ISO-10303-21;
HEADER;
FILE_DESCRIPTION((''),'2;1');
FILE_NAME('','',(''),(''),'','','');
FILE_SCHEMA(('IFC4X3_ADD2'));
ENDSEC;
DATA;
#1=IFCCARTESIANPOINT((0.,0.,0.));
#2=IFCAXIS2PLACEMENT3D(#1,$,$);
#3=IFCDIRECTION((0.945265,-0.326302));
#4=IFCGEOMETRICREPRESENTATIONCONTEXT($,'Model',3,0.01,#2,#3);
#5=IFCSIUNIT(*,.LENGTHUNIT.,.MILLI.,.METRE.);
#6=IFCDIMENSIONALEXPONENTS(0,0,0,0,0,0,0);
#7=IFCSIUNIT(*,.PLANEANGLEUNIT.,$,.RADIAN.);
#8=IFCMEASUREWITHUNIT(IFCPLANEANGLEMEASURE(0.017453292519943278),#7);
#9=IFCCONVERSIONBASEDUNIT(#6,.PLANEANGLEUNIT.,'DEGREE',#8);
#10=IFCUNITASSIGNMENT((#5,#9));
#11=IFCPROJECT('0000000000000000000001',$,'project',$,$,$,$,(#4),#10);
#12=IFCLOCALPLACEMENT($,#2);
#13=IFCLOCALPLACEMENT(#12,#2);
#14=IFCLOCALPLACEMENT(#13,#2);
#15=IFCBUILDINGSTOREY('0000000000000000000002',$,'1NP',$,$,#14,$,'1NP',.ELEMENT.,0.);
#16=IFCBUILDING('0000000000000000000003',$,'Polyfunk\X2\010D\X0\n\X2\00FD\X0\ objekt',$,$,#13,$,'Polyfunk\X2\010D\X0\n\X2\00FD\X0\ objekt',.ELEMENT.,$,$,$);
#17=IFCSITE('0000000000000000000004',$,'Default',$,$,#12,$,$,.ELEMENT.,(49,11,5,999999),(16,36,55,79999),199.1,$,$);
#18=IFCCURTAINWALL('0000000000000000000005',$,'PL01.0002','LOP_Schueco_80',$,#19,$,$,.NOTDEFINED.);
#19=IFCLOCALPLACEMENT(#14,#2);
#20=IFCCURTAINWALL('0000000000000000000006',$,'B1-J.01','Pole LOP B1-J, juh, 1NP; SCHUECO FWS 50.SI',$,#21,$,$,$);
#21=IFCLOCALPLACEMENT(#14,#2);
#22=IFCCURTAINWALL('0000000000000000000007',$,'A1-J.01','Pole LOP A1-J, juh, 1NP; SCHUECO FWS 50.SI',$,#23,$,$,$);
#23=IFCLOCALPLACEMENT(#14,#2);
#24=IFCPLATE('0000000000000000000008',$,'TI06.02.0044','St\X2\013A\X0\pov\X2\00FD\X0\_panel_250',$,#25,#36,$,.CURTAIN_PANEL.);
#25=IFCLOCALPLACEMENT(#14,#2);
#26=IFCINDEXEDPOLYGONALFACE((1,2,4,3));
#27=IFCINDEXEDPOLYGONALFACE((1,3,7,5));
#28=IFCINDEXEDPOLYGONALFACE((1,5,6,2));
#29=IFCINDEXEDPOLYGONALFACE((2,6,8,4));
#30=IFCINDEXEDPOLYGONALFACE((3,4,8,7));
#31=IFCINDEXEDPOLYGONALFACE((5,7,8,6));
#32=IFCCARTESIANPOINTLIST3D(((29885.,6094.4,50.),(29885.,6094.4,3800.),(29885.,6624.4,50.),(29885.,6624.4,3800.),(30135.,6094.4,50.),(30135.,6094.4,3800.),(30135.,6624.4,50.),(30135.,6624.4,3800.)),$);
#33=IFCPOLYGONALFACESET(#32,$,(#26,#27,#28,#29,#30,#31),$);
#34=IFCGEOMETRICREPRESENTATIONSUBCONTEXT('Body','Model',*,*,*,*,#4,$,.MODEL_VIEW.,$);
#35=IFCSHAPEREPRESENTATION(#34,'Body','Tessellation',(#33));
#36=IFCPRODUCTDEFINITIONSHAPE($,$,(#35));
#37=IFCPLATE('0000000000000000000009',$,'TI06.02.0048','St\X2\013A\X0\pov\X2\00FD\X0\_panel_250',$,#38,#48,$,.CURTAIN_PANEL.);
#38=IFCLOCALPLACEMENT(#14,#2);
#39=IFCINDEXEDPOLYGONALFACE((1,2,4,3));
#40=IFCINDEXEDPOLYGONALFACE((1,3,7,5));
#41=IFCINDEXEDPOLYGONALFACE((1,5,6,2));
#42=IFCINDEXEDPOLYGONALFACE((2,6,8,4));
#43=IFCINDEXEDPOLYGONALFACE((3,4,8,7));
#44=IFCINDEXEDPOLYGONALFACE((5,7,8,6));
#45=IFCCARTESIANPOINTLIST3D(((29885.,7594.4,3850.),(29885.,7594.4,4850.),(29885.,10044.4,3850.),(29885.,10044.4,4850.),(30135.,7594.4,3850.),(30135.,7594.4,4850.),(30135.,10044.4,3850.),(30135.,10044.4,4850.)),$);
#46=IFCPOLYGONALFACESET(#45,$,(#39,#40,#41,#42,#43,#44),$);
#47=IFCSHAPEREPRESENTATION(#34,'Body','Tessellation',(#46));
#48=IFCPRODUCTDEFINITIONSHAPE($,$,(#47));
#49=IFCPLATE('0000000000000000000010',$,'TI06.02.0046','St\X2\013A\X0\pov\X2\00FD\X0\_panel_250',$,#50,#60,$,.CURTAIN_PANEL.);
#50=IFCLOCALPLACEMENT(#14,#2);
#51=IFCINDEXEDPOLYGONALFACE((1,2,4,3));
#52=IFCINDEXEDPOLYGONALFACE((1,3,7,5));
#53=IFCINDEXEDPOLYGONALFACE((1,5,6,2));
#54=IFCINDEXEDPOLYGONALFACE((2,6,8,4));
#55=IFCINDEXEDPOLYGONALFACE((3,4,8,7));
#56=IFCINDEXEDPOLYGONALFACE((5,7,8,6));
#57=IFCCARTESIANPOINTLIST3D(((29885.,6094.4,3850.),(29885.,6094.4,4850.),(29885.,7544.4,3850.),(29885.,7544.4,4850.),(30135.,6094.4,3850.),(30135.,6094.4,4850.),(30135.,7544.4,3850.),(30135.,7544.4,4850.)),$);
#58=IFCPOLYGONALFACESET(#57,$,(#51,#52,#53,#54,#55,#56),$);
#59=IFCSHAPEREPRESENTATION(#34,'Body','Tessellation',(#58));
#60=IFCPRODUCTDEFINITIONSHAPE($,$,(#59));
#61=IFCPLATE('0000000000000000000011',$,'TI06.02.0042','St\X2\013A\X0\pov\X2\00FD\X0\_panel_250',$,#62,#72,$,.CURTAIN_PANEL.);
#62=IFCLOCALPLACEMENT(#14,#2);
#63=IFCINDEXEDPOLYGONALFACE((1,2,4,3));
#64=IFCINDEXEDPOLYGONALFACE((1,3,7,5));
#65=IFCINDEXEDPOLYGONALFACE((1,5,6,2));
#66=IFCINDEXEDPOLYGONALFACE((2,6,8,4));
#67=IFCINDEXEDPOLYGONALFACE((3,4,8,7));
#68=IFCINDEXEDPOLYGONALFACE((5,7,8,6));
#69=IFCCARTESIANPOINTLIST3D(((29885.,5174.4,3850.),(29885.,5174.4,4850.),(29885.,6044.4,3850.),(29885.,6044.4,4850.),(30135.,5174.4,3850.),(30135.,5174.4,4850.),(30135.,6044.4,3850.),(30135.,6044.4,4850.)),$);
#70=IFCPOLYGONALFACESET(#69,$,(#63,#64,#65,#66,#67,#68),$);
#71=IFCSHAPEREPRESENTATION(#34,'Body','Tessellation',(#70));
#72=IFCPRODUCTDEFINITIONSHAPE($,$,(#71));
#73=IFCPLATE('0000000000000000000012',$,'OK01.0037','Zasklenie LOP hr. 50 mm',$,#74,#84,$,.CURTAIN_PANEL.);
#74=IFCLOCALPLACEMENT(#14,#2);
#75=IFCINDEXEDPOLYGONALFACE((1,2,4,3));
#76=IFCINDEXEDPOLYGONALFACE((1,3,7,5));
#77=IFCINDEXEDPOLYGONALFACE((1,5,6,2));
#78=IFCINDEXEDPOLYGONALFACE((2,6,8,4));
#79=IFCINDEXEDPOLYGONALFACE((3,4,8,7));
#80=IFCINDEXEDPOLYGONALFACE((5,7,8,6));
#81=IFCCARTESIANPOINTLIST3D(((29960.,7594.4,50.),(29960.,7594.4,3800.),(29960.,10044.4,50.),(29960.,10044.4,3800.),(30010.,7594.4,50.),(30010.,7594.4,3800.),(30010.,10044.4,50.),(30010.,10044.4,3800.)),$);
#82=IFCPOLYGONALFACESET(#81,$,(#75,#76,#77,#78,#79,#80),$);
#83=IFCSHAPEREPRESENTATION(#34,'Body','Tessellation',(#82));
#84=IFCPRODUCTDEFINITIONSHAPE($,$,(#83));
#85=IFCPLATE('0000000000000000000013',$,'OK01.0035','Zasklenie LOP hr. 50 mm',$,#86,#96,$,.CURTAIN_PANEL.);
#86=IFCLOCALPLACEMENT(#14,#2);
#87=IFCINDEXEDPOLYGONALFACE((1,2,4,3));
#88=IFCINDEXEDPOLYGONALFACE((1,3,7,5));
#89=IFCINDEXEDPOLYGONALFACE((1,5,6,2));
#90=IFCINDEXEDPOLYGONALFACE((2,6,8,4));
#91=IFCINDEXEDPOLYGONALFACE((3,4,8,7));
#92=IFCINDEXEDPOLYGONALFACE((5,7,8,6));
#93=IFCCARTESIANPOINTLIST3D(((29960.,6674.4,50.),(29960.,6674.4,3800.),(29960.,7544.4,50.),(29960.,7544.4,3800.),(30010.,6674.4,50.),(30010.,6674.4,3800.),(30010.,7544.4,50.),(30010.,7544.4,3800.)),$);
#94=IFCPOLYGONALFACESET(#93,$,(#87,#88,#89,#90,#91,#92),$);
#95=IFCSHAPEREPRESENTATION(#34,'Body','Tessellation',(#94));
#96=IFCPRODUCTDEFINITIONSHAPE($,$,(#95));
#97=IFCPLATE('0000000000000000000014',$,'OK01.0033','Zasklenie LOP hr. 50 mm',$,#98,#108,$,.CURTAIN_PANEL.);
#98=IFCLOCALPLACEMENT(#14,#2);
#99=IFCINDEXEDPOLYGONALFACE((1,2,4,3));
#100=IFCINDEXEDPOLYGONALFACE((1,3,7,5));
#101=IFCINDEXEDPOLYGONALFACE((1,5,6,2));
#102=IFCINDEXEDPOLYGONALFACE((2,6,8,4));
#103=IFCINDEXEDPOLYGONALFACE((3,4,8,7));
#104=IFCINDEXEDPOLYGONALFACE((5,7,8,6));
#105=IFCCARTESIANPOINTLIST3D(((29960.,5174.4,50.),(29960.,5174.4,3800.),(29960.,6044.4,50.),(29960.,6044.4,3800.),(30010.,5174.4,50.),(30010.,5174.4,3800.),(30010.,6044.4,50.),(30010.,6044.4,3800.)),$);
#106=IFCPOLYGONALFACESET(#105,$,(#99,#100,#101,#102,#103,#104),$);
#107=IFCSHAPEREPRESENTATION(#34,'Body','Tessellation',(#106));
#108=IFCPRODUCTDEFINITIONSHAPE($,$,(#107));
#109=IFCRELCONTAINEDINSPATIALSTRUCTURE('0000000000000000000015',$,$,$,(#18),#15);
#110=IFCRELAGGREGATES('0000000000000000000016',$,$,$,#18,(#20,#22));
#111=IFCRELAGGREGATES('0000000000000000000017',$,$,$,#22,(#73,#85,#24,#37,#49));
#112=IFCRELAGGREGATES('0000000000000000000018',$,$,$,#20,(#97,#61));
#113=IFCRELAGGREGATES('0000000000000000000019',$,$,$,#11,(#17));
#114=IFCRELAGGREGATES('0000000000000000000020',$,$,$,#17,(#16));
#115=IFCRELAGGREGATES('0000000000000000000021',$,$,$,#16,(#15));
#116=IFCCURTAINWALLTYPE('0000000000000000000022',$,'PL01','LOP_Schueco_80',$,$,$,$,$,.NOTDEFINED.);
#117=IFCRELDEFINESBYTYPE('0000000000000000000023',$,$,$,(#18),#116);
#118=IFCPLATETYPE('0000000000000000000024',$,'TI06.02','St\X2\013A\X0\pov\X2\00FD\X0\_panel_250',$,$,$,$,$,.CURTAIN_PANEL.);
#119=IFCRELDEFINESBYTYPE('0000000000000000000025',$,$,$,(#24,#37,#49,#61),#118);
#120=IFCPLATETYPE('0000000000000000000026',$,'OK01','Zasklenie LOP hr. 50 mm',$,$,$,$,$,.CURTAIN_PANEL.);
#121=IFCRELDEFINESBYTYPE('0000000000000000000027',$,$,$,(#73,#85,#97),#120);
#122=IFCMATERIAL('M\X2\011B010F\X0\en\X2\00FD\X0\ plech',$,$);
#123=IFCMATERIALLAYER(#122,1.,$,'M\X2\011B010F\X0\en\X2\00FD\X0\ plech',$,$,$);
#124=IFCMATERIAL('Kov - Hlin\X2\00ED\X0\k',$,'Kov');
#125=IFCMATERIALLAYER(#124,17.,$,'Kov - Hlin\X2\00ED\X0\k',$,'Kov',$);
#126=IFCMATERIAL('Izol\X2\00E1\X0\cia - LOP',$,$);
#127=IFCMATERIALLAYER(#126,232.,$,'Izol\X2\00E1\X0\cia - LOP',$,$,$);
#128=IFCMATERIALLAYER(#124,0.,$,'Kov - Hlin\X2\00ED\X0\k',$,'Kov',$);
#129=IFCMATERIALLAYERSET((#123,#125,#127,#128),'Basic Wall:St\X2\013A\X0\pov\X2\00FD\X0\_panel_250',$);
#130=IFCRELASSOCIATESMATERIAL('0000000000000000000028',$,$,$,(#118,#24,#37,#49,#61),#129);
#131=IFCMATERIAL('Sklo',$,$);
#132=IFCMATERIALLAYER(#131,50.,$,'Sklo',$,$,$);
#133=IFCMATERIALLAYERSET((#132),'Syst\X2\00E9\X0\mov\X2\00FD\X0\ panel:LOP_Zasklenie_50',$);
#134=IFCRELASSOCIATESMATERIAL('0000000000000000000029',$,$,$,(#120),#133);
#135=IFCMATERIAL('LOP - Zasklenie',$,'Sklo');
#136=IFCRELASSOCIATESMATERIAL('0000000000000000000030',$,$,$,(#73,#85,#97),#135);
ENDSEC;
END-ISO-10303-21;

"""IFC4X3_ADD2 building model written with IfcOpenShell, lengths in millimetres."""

from ifc_helpers import new_model, entity, si_unit, converted_unit, direction, frame, frame_2d, origin, place, context, subcontext, project, spatial, rectangle, extrude, source, transform, mapped, material, layer, layer_set, layer_usage, type_object, type_shapes, element, aggregate, save


model = new_model("IFC4X3_ADD2")

# Units and contexts
model_context = context("Model", 3, precision=0.01, world=origin(), true_north=direction((0.945265, -0.326302)))
body_context = subcontext(model_context, "Body", "Model", "MODEL_VIEW")
ifc_project = project(units=[si_unit("LENGTHUNIT", "METRE", prefix="MILLI"), converted_unit("PLANEANGLEUNIT", "DEGREE", entity("IfcPlaneAngleMeasure", 0.017453292519943278), si_unit("PLANEANGLEUNIT", "RADIAN"), dimensions=[0, 0, 0, 0, 0, 0, 0])], contexts=[model_context])

# Site, building, storey
site_placement = place(None, origin())
site = spatial("IfcSite", under=ifc_project, at=site_placement, Name="Default", CompositionType="ELEMENT", RefLatitude=(49, 11, 5, 999999), RefLongitude=(16, 36, 55, 79999), RefElevation=199.1)
building_placement = place(site_placement, origin())
building = spatial("IfcBuilding", under=site, at=building_placement, Name="Polyfunkčný objekt", LongName="Polyfunkčný objekt", CompositionType="ELEMENT")
storey_placement = place(building_placement, origin())
storey = spatial("IfcBuildingStorey", under=building, at=storey_placement, Name="1NP", LongName="1NP", CompositionType="ELEMENT", Elevation=0.0)

# Curtain walls, plates
curtain_wall_type = type_object("IfcCurtainWallType", Name="PL01", Description="LOP_Schueco_80", PredefinedType="NOTDEFINED")
curtain_wall_1_placement = place(storey_placement, origin())
curtain_wall_1 = element("IfcCurtainWall", 1, at=curtain_wall_1_placement, inside=storey, type_object=curtain_wall_type, Name="PL01.0002", Description="LOP_Schueco_80", PredefinedType="NOTDEFINED")
curtain_wall_2 = element("IfcCurtainWall", 2, Name="B1-J.01", Description="Pole LOP B1-J, juh, 1NP; SCHUECO FWS 50.SI")
curtain_wall_3 = element("IfcCurtainWall", 3, Name="A1-J.01", Description="Pole LOP A1-J, juh, 1NP; SCHUECO FWS 50.SI")
aggregate(curtain_wall_1, [curtain_wall_2, curtain_wall_3])
ifc_material_1 = material(Name="Měďený plech")
ifc_layer_1 = layer(ifc_material_1, 1.0, Name="Měďený plech")
ifc_material_2 = material(Name="Kov - Hliník", Category="Kov")
ifc_layer_2 = layer(ifc_material_2, 17.0, Name="Kov - Hliník", Category="Kov")
ifc_material_3 = material(Name="Izolácia - LOP")
ifc_layer_3 = layer(ifc_material_3, 232.0, Name="Izolácia - LOP")
ifc_layer_4 = layer(ifc_material_2, 0.0, Name="Kov - Hliník", Category="Kov")
ifc_layer_set_1 = layer_set([ifc_layer_1, ifc_layer_2, ifc_layer_3, ifc_layer_4], Name="Basic Wall:Stĺpový_panel_250")
ifc_layer_usage_1 = layer_usage(ifc_layer_set_1, "AXIS2", "POSITIVE", -125.0)
plate_type_1 = type_object("IfcPlateType", Name="TI06.02", Description="Stĺpový_panel_250", PredefinedType="CURTAIN_PANEL", material=ifc_layer_set_1)
plate_1_placement = place(storey_placement, frame((30010.0, 6624.4, 50.0), z_axis=(0.0, 0.0, 1.0), x_axis=(0.0, -1.0, 0.0)))
plate_1 = element("IfcPlate", 4, at=plate_1_placement, type_object=plate_type_1, material=ifc_layer_usage_1, Name="TI06.02.0044", Description="Stĺpový_panel_250", PredefinedType="CURTAIN_PANEL", context=body_context, shape_type="SweptSolid", body=[
    extrude(rectangle(XDim=250.0, YDim=530.0, at=frame_2d((0.0, 0.0), x_axis=(1.0, 0.0))), frame((265.0, 0.0, 0.0), z_axis=(0.0, 0.0, 1.0), x_axis=(0.0, 1.0, 0.0)), (0.0, 0.0, 1.0), 3750.0),
])
ifc_layer_usage_2 = layer_usage(ifc_layer_set_1, "AXIS2", "POSITIVE", -125.0)
plate_2_placement = place(storey_placement, frame((30010.0, 10044.4, 3850.0), z_axis=(0.0, 0.0, 1.0), x_axis=(0.0, -1.0, 0.0)))
plate_2 = element("IfcPlate", 5, at=plate_2_placement, type_object=plate_type_1, material=ifc_layer_usage_2, Name="TI06.02.0048", Description="Stĺpový_panel_250", PredefinedType="CURTAIN_PANEL", context=body_context, shape_type="SweptSolid", body=[
    extrude(rectangle(XDim=250.0, YDim=2450.0, at=frame_2d((0.0, 0.0), x_axis=(1.0, 0.0))), frame((1225.0, 0.0, 0.0), z_axis=(0.0, 0.0, 1.0), x_axis=(0.0, 1.0, 0.0)), (0.0, 0.0, 1.0), 1000.0),
])
ifc_layer_usage_3 = layer_usage(ifc_layer_set_1, "AXIS2", "POSITIVE", -125.0)
plate_3_placement = place(storey_placement, frame((30010.0, 7544.4, 3850.0), z_axis=(0.0, 0.0, 1.0), x_axis=(0.0, -1.0, 0.0)))
plate_3 = element("IfcPlate", 6, at=plate_3_placement, type_object=plate_type_1, material=ifc_layer_usage_3, Name="TI06.02.0046", Description="Stĺpový_panel_250", PredefinedType="CURTAIN_PANEL", context=body_context, shape_type="SweptSolid", body=[
    extrude(rectangle(XDim=250.0, YDim=1450.0, at=frame_2d((0.0, 0.0), x_axis=(1.0, 0.0))), frame((725.0, 0.0, 0.0), z_axis=(0.0, 0.0, 1.0), x_axis=(0.0, 1.0, 0.0)), (0.0, 0.0, 1.0), 1000.0),
])
ifc_layer_usage_4 = layer_usage(ifc_layer_set_1, "AXIS2", "POSITIVE", -125.0)
plate_4_placement = place(storey_placement, frame((30010.0, 6044.4, 3850.0), z_axis=(0.0, 0.0, 1.0), x_axis=(0.0, -1.0, 0.0)))
plate_4 = element("IfcPlate", 7, at=plate_4_placement, type_object=plate_type_1, material=ifc_layer_usage_4, Name="TI06.02.0042", Description="Stĺpový_panel_250", PredefinedType="CURTAIN_PANEL", context=body_context, shape_type="SweptSolid", body=[
    extrude(rectangle(XDim=250.0, YDim=870.0, at=frame_2d((0.0, 0.0), x_axis=(1.0, 0.0))), frame((435.0, 0.0, 0.0), z_axis=(0.0, 0.0, 1.0), x_axis=(0.0, 1.0, 0.0)), (0.0, 0.0, 1.0), 1000.0),
])
ifc_material_4 = material(Name="LOP - Zasklenie", Category="Sklo")
ifc_material_5 = material(Name="Sklo")
ifc_layer_5 = layer(ifc_material_5, 50.0, Name="Sklo")
ifc_layer_set_2 = layer_set([ifc_layer_5], Name="Systémový panel:LOP_Zasklenie_50")
plate_type_2 = type_object("IfcPlateType", Name="OK01", Description="Zasklenie LOP hr. 50 mm", PredefinedType="CURTAIN_PANEL", material=ifc_layer_set_2)
shared_shape_1 = source(origin(), body_context, "Body", "SweptSolid", [
    extrude(rectangle(XDim=3750.0, YDim=2450.0, at=frame_2d((-141.7, 0.0), x_axis=(1.0, 0.0))), frame((0.0, -50.0, 2016.7), z_axis=(0.0, 1.0, 0.0), x_axis=(0.0, 0.0, 1.0)), (0.0, 0.0, 1.0), 50.0),
])
plate_5_placement = place(curtain_wall_1_placement, frame((30010.0, 8819.4, 50.0), z_axis=(0.0, 0.0, 1.0), x_axis=(0.0, -1.0, 0.0)))
plate_5 = element("IfcPlate", 8, at=plate_5_placement, type_object=plate_type_2, material=ifc_material_4, Name="OK01.0037", Description="Zasklenie LOP hr. 50 mm", PredefinedType="CURTAIN_PANEL", context=body_context, shape_type="MappedRepresentation", body=[
    mapped(shared_shape_1, transform((0.0, 0.0, 0.0), scale=1.0)),
])
shared_shape_2 = source(origin(), body_context, "Body", "SweptSolid", [
    extrude(rectangle(XDim=3750.0, YDim=870.0, at=frame_2d((-141.7, 0.0), x_axis=(1.0, 0.0))), frame((0.0, -50.0, 2016.7), z_axis=(0.0, 1.0, 0.0), x_axis=(0.0, 0.0, 1.0)), (0.0, 0.0, 1.0), 50.0),
])
type_shapes(plate_type_2, [shared_shape_1, shared_shape_2])
plate_6_placement = place(curtain_wall_1_placement, frame((30010.0, 7109.4, 50.0), z_axis=(0.0, 0.0, 1.0), x_axis=(0.0, -1.0, 0.0)))
plate_6 = element("IfcPlate", 9, at=plate_6_placement, type_object=plate_type_2, material=ifc_material_4, Name="OK01.0035", Description="Zasklenie LOP hr. 50 mm", PredefinedType="CURTAIN_PANEL", context=body_context, shape_type="MappedRepresentation", body=[
    mapped(shared_shape_2, transform((0.0, 0.0, 0.0), scale=1.0)),
])
aggregate(curtain_wall_3, [plate_5, plate_6, plate_1, plate_2, plate_3])
plate_7_placement = place(curtain_wall_1_placement, frame((30010.0, 5609.4, 50.0), z_axis=(0.0, 0.0, 1.0), x_axis=(0.0, -1.0, 0.0)))
plate_7 = element("IfcPlate", 10, at=plate_7_placement, type_object=plate_type_2, material=ifc_material_4, Name="OK01.0033", Description="Zasklenie LOP hr. 50 mm", PredefinedType="CURTAIN_PANEL", context=body_context, shape_type="MappedRepresentation", body=[
    mapped(shared_shape_2, transform((0.0, 0.0, 0.0), scale=1.0)),
])
aggregate(curtain_wall_2, [plate_7, plate_4])

save(model, "model.ifc")
